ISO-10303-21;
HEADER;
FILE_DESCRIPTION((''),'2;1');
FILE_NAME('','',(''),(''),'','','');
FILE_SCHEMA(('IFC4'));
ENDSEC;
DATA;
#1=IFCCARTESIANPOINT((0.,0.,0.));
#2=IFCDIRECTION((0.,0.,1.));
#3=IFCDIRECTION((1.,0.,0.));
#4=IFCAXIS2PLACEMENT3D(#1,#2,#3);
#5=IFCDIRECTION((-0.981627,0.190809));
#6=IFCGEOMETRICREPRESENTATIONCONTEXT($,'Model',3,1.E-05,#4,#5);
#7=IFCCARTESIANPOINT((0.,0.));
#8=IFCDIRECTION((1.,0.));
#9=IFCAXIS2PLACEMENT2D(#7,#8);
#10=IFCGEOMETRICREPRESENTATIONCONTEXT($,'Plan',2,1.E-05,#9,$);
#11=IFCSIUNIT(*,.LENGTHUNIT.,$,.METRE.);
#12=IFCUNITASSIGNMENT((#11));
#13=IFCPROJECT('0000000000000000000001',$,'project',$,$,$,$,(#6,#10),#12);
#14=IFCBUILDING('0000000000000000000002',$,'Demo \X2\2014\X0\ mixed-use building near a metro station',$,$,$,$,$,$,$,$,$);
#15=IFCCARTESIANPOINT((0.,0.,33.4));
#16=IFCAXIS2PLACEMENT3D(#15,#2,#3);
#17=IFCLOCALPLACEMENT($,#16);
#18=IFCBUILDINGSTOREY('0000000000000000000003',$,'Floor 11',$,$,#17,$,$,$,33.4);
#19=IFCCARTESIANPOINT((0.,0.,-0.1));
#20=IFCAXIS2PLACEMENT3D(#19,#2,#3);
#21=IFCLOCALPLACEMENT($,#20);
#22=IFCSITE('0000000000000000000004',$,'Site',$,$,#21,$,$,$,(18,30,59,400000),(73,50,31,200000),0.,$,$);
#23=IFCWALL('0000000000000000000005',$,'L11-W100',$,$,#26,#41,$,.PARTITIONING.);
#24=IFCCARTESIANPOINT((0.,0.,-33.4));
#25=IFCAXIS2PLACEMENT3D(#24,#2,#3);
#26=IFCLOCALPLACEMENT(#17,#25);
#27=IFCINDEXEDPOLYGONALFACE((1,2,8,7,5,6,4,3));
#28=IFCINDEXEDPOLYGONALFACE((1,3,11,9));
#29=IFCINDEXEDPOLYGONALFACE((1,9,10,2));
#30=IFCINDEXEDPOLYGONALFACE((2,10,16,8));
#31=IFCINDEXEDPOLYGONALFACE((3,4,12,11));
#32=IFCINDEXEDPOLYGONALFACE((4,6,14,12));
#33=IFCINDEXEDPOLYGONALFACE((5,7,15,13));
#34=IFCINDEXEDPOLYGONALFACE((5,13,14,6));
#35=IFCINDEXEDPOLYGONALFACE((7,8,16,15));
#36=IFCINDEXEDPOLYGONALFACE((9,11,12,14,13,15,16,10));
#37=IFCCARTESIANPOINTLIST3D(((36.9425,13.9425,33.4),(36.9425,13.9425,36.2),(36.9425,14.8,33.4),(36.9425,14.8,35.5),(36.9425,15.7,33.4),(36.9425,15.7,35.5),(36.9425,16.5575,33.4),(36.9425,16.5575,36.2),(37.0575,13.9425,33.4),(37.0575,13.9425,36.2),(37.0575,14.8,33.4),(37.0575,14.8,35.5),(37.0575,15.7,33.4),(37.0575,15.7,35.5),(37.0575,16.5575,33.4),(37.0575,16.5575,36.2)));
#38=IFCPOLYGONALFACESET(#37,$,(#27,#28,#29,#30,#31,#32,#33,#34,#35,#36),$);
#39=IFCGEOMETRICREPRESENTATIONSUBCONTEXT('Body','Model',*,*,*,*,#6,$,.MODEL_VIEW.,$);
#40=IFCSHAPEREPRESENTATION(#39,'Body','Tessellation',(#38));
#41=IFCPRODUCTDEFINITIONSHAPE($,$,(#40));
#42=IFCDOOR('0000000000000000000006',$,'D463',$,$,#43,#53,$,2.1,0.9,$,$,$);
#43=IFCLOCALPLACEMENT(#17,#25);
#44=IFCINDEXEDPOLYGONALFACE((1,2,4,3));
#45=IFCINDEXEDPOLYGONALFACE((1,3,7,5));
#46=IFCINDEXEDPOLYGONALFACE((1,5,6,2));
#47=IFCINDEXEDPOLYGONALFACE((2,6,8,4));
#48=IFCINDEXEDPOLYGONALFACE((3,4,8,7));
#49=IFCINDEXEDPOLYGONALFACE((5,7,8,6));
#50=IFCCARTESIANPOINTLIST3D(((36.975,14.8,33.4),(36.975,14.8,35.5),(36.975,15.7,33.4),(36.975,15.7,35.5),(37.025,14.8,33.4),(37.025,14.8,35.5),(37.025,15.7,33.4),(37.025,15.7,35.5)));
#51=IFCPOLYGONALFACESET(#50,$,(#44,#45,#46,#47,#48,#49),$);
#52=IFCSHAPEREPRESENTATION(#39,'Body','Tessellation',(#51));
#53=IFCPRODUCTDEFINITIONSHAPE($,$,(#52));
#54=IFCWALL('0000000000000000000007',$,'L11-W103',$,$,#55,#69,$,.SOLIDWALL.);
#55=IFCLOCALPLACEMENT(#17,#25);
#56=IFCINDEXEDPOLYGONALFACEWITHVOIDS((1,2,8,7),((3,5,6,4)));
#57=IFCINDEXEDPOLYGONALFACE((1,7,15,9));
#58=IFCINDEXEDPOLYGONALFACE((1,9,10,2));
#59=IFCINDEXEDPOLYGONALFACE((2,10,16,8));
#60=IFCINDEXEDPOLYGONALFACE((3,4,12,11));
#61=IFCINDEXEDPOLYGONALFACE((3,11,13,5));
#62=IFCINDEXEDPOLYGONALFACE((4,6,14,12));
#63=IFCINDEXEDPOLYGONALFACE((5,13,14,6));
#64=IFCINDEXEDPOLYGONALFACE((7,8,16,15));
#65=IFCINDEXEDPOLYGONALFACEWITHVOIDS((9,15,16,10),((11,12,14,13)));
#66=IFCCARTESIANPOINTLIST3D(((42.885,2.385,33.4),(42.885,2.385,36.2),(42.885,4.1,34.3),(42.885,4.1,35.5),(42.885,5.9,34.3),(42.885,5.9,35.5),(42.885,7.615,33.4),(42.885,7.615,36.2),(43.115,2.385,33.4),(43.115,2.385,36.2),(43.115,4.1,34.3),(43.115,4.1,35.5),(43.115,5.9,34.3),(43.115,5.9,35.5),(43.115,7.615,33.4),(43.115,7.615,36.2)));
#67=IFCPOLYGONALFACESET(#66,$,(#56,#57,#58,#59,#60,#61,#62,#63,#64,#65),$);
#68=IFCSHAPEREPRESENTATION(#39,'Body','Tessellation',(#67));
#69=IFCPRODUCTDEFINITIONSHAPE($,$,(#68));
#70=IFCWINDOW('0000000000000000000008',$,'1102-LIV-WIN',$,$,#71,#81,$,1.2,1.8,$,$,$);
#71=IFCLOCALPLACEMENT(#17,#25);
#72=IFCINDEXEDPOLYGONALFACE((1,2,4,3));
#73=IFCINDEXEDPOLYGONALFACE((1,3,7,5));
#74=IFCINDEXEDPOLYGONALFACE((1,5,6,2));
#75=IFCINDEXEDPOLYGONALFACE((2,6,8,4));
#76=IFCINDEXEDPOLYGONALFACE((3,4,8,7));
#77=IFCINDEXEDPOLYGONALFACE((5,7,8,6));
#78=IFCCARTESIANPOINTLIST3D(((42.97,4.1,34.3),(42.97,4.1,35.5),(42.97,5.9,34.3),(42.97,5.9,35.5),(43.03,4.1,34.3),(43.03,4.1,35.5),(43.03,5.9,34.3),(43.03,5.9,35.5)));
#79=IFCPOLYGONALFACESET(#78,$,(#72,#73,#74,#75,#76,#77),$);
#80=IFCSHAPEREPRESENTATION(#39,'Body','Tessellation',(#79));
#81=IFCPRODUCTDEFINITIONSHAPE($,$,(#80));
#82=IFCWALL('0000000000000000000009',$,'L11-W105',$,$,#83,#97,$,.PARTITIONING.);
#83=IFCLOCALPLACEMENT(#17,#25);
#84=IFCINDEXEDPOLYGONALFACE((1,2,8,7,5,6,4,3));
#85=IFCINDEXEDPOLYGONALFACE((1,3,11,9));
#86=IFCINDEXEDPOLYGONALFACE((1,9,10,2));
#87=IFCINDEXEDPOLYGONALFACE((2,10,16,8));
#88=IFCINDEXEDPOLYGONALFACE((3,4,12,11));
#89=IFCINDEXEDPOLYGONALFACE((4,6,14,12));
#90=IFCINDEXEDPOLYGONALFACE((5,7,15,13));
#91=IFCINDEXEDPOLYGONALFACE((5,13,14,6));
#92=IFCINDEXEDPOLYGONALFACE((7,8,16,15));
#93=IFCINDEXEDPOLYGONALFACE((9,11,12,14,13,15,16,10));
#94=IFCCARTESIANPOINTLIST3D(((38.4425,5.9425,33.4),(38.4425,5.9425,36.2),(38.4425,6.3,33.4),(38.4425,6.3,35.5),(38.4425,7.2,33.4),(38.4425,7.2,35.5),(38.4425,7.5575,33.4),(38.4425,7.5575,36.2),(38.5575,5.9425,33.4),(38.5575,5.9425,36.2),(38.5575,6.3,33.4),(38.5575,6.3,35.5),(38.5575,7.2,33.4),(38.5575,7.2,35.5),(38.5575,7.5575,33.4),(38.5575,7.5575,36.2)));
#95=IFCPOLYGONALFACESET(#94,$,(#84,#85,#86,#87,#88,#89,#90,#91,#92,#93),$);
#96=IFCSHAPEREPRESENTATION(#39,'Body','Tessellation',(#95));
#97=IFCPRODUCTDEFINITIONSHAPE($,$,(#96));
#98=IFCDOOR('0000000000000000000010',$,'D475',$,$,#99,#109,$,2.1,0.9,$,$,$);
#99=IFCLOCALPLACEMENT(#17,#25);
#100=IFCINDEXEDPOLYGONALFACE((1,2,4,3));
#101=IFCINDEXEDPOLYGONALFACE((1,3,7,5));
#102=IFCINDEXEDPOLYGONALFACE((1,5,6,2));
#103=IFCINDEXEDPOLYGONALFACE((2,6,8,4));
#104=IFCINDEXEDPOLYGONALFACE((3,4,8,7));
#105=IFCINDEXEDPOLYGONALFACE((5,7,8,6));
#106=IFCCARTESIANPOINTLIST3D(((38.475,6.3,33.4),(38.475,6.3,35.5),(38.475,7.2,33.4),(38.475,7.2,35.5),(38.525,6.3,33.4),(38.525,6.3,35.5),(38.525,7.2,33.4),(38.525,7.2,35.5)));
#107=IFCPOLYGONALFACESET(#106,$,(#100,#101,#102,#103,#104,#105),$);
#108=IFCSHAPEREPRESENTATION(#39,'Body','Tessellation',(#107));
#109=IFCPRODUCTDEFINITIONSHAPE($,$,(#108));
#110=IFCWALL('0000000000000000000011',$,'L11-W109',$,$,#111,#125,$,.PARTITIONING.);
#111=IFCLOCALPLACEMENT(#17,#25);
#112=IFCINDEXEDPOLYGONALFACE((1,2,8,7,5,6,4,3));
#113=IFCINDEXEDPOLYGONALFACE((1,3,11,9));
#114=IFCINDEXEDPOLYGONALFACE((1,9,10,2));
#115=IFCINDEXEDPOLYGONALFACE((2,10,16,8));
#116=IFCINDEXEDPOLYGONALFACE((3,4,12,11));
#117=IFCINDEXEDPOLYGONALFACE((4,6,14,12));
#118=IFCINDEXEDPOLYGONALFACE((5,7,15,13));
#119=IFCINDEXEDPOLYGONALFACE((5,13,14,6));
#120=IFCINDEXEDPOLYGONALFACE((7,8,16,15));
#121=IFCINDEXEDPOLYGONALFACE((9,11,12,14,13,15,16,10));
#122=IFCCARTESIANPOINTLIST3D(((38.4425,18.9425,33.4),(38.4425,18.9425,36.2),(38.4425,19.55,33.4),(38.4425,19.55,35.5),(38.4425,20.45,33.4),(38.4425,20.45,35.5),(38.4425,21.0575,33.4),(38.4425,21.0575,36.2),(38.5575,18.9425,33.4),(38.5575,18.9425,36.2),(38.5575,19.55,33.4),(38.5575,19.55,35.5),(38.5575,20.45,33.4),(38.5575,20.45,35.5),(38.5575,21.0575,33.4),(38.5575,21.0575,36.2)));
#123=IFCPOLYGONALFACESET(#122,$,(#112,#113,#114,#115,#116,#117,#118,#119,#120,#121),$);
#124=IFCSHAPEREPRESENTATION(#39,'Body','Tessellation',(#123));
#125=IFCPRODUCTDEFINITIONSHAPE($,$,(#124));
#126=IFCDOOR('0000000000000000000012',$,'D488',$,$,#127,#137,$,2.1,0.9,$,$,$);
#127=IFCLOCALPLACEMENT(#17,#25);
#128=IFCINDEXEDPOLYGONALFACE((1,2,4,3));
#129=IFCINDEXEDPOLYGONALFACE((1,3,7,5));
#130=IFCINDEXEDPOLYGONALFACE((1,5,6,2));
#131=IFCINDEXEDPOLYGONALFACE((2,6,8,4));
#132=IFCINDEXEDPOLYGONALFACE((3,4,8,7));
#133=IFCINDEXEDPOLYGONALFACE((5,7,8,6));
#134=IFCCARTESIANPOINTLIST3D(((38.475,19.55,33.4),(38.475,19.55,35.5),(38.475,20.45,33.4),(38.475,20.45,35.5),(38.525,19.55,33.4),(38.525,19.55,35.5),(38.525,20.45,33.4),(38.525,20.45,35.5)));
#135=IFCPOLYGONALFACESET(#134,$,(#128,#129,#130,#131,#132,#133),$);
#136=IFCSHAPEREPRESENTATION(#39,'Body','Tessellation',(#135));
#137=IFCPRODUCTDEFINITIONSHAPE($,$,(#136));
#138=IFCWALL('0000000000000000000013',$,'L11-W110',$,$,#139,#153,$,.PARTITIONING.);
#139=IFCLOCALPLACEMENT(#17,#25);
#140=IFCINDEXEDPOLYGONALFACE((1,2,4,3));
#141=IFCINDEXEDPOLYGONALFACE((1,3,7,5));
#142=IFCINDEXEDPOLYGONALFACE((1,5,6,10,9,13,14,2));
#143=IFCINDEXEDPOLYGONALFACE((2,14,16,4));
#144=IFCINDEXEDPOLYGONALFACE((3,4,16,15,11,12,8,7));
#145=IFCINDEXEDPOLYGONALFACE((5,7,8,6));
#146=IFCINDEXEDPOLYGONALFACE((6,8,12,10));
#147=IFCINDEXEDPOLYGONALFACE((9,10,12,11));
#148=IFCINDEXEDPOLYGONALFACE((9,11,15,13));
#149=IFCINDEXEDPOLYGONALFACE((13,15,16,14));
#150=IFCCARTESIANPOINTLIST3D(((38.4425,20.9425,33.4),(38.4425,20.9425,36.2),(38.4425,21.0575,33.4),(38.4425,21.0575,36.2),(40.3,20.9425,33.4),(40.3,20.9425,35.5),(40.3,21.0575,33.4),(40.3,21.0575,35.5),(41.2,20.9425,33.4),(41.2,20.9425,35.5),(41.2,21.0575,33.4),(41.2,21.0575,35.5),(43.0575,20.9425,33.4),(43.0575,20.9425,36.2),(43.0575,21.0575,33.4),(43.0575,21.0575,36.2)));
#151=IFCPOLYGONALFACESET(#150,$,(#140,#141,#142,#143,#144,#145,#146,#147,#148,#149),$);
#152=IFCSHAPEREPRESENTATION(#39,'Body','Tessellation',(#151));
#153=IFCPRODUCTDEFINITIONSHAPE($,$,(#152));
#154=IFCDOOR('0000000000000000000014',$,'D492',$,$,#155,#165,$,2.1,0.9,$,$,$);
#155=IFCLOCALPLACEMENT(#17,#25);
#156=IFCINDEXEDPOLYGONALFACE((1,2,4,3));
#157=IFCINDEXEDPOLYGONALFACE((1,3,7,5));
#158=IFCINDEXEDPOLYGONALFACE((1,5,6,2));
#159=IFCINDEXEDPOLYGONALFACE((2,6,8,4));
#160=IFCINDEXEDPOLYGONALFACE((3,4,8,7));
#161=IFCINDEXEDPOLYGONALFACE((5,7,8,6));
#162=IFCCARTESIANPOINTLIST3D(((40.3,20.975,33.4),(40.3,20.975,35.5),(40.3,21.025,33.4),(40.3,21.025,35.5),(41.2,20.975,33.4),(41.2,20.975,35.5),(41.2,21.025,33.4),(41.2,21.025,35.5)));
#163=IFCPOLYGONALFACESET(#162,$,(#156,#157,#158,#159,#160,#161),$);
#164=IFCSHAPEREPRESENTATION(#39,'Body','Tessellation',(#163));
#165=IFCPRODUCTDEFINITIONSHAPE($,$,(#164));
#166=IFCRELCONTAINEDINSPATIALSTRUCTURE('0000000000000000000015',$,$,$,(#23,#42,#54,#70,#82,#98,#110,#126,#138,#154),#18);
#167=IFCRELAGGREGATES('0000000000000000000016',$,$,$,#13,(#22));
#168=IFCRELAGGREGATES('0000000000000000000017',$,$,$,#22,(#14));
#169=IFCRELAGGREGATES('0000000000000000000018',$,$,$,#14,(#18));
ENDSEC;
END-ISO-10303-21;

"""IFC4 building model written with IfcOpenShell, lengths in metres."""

from ifc_helpers import new_model, si_unit, direction, frame, origin_with_axes, origin_2d_with_axis, place, context, subcontext, project, spatial, line, indexed_curve, outline, extrude, element, fill, save


model = new_model("IFC4")

# Units and contexts
model_context = context("Model", 3, precision=1e-05, world=origin_with_axes(), true_north=direction((-0.981627, 0.190809)))
plan_context = context("Plan", 2, precision=1e-05, world=origin_2d_with_axis())
body_context = subcontext(model_context, "Body", "Model", "MODEL_VIEW")
ifc_project = project(units=[si_unit("LENGTHUNIT", "METRE")], contexts=[model_context, plan_context])

# Site, building, storey
site_placement = place(None, frame((0.0, 0.0, -0.1), z_axis=(0.0, 0.0, 1.0), x_axis=(1.0, 0.0, 0.0)))
site = spatial("IfcSite", under=ifc_project, at=site_placement, Name="Site", RefLatitude=(18, 30, 59, 400000), RefLongitude=(73, 50, 31, 200000), RefElevation=0.0)
building = spatial("IfcBuilding", under=site, Name="Demo — mixed-use building near a metro station")
storey_placement = place(None, frame((0.0, 0.0, 33.4), z_axis=(0.0, 0.0, 1.0), x_axis=(1.0, 0.0, 0.0)))
storey = spatial("IfcBuildingStorey", under=building, at=storey_placement, Name="Floor 11", Elevation=33.4)

# Wall, opening, door
wall_1_placement = place(storey_placement, frame((0.0, 0.0, -33.4), z_axis=(0.0, 0.0, 1.0), x_axis=(1.0, 0.0, 0.0)))
wall_1 = element("IfcWall", 1, at=wall_1_placement, inside=storey, Name="L11-W100", PredefinedType="PARTITIONING", context=body_context, shape_type="SweptSolid", body=[
    extrude(outline(indexed_curve([(36.9425, 13.9425), (36.9425, 16.5575), (37.0575, 16.5575), (37.0575, 13.9425)], segments=[line(1, 2, 3, 4, 1)])), frame((0.0, 0.0, 33.4), z_axis=(0.0, 0.0, 1.0), x_axis=(1.0, 0.0, 0.0)), (0.0, 0.0, 1.0), 2.8),
])
opening_1_placement = place(wall_1_placement, origin_with_axes())
opening_1 = element("IfcOpeningElement", 2, at=opening_1_placement, cuts=wall_1, context=body_context, shape_type="SweptSolid", body=[
    extrude(outline(indexed_curve([(36.8925, 14.8), (36.8925, 15.7), (37.1075, 15.7), (37.1075, 14.8)], segments=[line(1, 2, 3, 4, 1)])), frame((0.0, 0.0, 33.4), z_axis=(0.0, 0.0, 1.0), x_axis=(1.0, 0.0, 0.0)), (0.0, 0.0, 1.0), 2.1),
])
door_1_placement = place(storey_placement, frame((0.0, 0.0, -33.4), z_axis=(0.0, 0.0, 1.0), x_axis=(1.0, 0.0, 0.0)))
door_1 = element("IfcDoor", 3, at=door_1_placement, inside=storey, Name="D463", OverallHeight=2.1, OverallWidth=0.9, context=body_context, shape_type="SweptSolid", body=[
    extrude(outline(indexed_curve([(36.975, 14.8), (36.975, 15.7), (37.025, 15.7), (37.025, 14.8)], segments=[line(1, 2, 3, 4, 1)])), frame((0.0, 0.0, 33.4), z_axis=(0.0, 0.0, 1.0), x_axis=(1.0, 0.0, 0.0)), (0.0, 0.0, 1.0), 2.1),
])
fill(opening_1, door_1)

# Wall, opening, window
wall_2_placement = place(storey_placement, frame((0.0, 0.0, -33.4), z_axis=(0.0, 0.0, 1.0), x_axis=(1.0, 0.0, 0.0)))
wall_2 = element("IfcWall", 4, at=wall_2_placement, inside=storey, Name="L11-W103", PredefinedType="SOLIDWALL", context=body_context, shape_type="SweptSolid", body=[
    extrude(outline(indexed_curve([(42.885, 2.385), (42.885, 7.615), (43.115, 7.615), (43.115, 2.385)], segments=[line(1, 2, 3, 4, 1)])), frame((0.0, 0.0, 33.4), z_axis=(0.0, 0.0, 1.0), x_axis=(1.0, 0.0, 0.0)), (0.0, 0.0, 1.0), 2.8),
])
opening_2_placement = place(wall_2_placement, origin_with_axes())
opening_2 = element("IfcOpeningElement", 5, at=opening_2_placement, cuts=wall_2, context=body_context, shape_type="SweptSolid", body=[
    extrude(outline(indexed_curve([(42.835, 4.1), (42.835, 5.9), (43.165, 5.9), (43.165, 4.1)], segments=[line(1, 2, 3, 4, 1)])), frame((0.0, 0.0, 34.3), z_axis=(0.0, 0.0, 1.0), x_axis=(1.0, 0.0, 0.0)), (0.0, 0.0, 1.0), 1.2),
])
window_placement = place(storey_placement, frame((0.0, 0.0, -33.4), z_axis=(0.0, 0.0, 1.0), x_axis=(1.0, 0.0, 0.0)))
window = element("IfcWindow", 6, at=window_placement, inside=storey, Name="1102-LIV-WIN", OverallHeight=1.2, OverallWidth=1.8, context=body_context, shape_type="SweptSolid", body=[
    extrude(outline(indexed_curve([(42.97, 4.1), (42.97, 5.9), (43.03, 5.9), (43.03, 4.1)], segments=[line(1, 2, 3, 4, 1)])), frame((0.0, 0.0, 34.3), z_axis=(0.0, 0.0, 1.0), x_axis=(1.0, 0.0, 0.0)), (0.0, 0.0, 1.0), 1.2),
])
fill(opening_2, window)

# Wall, opening, door
wall_3_placement = place(storey_placement, frame((0.0, 0.0, -33.4), z_axis=(0.0, 0.0, 1.0), x_axis=(1.0, 0.0, 0.0)))
wall_3 = element("IfcWall", 7, at=wall_3_placement, inside=storey, Name="L11-W105", PredefinedType="PARTITIONING", context=body_context, shape_type="SweptSolid", body=[
    extrude(outline(indexed_curve([(38.5575, 7.5575), (38.5575, 5.9425), (38.4425, 5.9425), (38.4425, 7.5575)], segments=[line(1, 2, 3, 4, 1)])), frame((0.0, 0.0, 33.4), z_axis=(0.0, 0.0, 1.0), x_axis=(1.0, 0.0, 0.0)), (0.0, 0.0, 1.0), 2.8),
])
opening_3_placement = place(wall_3_placement, origin_with_axes())
opening_3 = element("IfcOpeningElement", 8, at=opening_3_placement, cuts=wall_3, context=body_context, shape_type="SweptSolid", body=[
    extrude(outline(indexed_curve([(38.6075, 7.2), (38.6075, 6.3), (38.3925, 6.3), (38.3925, 7.2)], segments=[line(1, 2, 3, 4, 1)])), frame((0.0, 0.0, 33.4), z_axis=(0.0, 0.0, 1.0), x_axis=(1.0, 0.0, 0.0)), (0.0, 0.0, 1.0), 2.1),
])
door_2_placement = place(storey_placement, frame((0.0, 0.0, -33.4), z_axis=(0.0, 0.0, 1.0), x_axis=(1.0, 0.0, 0.0)))
door_2 = element("IfcDoor", 9, at=door_2_placement, inside=storey, Name="D475", OverallHeight=2.1, OverallWidth=0.9, context=body_context, shape_type="SweptSolid", body=[
    extrude(outline(indexed_curve([(38.525, 7.2), (38.525, 6.3), (38.475, 6.3), (38.475, 7.2)], segments=[line(1, 2, 3, 4, 1)])), frame((0.0, 0.0, 33.4), z_axis=(0.0, 0.0, 1.0), x_axis=(1.0, 0.0, 0.0)), (0.0, 0.0, 1.0), 2.1),
])
fill(opening_3, door_2)

# Walls, openings, doors
wall_4_placement = place(storey_placement, frame((0.0, 0.0, -33.4), z_axis=(0.0, 0.0, 1.0), x_axis=(1.0, 0.0, 0.0)))
wall_4 = element("IfcWall", 10, at=wall_4_placement, inside=storey, Name="L11-W109", PredefinedType="PARTITIONING", context=body_context, shape_type="SweptSolid", body=[
    extrude(outline(indexed_curve([(38.5575, 21.0575), (38.5575, 18.9425), (38.4425, 18.9425), (38.4425, 21.0575)], segments=[line(1, 2, 3, 4, 1)])), frame((0.0, 0.0, 33.4), z_axis=(0.0, 0.0, 1.0), x_axis=(1.0, 0.0, 0.0)), (0.0, 0.0, 1.0), 2.8),
])
opening_4_placement = place(wall_4_placement, origin_with_axes())
opening_4 = element("IfcOpeningElement", 11, at=opening_4_placement, cuts=wall_4, context=body_context, shape_type="SweptSolid", body=[
    extrude(outline(indexed_curve([(38.6075, 20.45), (38.6075, 19.55), (38.3925, 19.55), (38.3925, 20.45)], segments=[line(1, 2, 3, 4, 1)])), frame((0.0, 0.0, 33.4), z_axis=(0.0, 0.0, 1.0), x_axis=(1.0, 0.0, 0.0)), (0.0, 0.0, 1.0), 2.1),
])
door_3_placement = place(storey_placement, frame((0.0, 0.0, -33.4), z_axis=(0.0, 0.0, 1.0), x_axis=(1.0, 0.0, 0.0)))
door_3 = element("IfcDoor", 12, at=door_3_placement, inside=storey, Name="D488", OverallHeight=2.1, OverallWidth=0.9, context=body_context, shape_type="SweptSolid", body=[
    extrude(outline(indexed_curve([(38.525, 20.45), (38.525, 19.55), (38.475, 19.55), (38.475, 20.45)], segments=[line(1, 2, 3, 4, 1)])), frame((0.0, 0.0, 33.4), z_axis=(0.0, 0.0, 1.0), x_axis=(1.0, 0.0, 0.0)), (0.0, 0.0, 1.0), 2.1),
])
fill(opening_4, door_3)
wall_5_placement = place(storey_placement, frame((0.0, 0.0, -33.4), z_axis=(0.0, 0.0, 1.0), x_axis=(1.0, 0.0, 0.0)))
wall_5 = element("IfcWall", 13, at=wall_5_placement, inside=storey, Name="L11-W110", PredefinedType="PARTITIONING", context=body_context, shape_type="SweptSolid", body=[
    extrude(outline(indexed_curve([(43.0575, 20.9425), (38.4425, 20.9425), (38.4425, 21.0575), (43.0575, 21.0575)], segments=[line(1, 2, 3, 4, 1)])), frame((0.0, 0.0, 33.4), z_axis=(0.0, 0.0, 1.0), x_axis=(1.0, 0.0, 0.0)), (0.0, 0.0, 1.0), 2.8),
])
opening_5_placement = place(wall_5_placement, origin_with_axes())
opening_5 = element("IfcOpeningElement", 14, at=opening_5_placement, cuts=wall_5, context=body_context, shape_type="SweptSolid", body=[
    extrude(outline(indexed_curve([(41.2, 20.8925), (40.3, 20.8925), (40.3, 21.1075), (41.2, 21.1075)], segments=[line(1, 2, 3, 4, 1)])), frame((0.0, 0.0, 33.4), z_axis=(0.0, 0.0, 1.0), x_axis=(1.0, 0.0, 0.0)), (0.0, 0.0, 1.0), 2.1),
])
door_4_placement = place(storey_placement, frame((0.0, 0.0, -33.4), z_axis=(0.0, 0.0, 1.0), x_axis=(1.0, 0.0, 0.0)))
door_4 = element("IfcDoor", 15, at=door_4_placement, inside=storey, Name="D492", OverallHeight=2.1, OverallWidth=0.9, context=body_context, shape_type="SweptSolid", body=[
    extrude(outline(indexed_curve([(41.2, 20.975), (40.3, 20.975), (40.3, 21.025), (41.2, 21.025)], segments=[line(1, 2, 3, 4, 1)])), frame((0.0, 0.0, 33.4), z_axis=(0.0, 0.0, 1.0), x_axis=(1.0, 0.0, 0.0)), (0.0, 0.0, 1.0), 2.1),
])
fill(opening_5, door_4)

save(model, "model.ifc")
